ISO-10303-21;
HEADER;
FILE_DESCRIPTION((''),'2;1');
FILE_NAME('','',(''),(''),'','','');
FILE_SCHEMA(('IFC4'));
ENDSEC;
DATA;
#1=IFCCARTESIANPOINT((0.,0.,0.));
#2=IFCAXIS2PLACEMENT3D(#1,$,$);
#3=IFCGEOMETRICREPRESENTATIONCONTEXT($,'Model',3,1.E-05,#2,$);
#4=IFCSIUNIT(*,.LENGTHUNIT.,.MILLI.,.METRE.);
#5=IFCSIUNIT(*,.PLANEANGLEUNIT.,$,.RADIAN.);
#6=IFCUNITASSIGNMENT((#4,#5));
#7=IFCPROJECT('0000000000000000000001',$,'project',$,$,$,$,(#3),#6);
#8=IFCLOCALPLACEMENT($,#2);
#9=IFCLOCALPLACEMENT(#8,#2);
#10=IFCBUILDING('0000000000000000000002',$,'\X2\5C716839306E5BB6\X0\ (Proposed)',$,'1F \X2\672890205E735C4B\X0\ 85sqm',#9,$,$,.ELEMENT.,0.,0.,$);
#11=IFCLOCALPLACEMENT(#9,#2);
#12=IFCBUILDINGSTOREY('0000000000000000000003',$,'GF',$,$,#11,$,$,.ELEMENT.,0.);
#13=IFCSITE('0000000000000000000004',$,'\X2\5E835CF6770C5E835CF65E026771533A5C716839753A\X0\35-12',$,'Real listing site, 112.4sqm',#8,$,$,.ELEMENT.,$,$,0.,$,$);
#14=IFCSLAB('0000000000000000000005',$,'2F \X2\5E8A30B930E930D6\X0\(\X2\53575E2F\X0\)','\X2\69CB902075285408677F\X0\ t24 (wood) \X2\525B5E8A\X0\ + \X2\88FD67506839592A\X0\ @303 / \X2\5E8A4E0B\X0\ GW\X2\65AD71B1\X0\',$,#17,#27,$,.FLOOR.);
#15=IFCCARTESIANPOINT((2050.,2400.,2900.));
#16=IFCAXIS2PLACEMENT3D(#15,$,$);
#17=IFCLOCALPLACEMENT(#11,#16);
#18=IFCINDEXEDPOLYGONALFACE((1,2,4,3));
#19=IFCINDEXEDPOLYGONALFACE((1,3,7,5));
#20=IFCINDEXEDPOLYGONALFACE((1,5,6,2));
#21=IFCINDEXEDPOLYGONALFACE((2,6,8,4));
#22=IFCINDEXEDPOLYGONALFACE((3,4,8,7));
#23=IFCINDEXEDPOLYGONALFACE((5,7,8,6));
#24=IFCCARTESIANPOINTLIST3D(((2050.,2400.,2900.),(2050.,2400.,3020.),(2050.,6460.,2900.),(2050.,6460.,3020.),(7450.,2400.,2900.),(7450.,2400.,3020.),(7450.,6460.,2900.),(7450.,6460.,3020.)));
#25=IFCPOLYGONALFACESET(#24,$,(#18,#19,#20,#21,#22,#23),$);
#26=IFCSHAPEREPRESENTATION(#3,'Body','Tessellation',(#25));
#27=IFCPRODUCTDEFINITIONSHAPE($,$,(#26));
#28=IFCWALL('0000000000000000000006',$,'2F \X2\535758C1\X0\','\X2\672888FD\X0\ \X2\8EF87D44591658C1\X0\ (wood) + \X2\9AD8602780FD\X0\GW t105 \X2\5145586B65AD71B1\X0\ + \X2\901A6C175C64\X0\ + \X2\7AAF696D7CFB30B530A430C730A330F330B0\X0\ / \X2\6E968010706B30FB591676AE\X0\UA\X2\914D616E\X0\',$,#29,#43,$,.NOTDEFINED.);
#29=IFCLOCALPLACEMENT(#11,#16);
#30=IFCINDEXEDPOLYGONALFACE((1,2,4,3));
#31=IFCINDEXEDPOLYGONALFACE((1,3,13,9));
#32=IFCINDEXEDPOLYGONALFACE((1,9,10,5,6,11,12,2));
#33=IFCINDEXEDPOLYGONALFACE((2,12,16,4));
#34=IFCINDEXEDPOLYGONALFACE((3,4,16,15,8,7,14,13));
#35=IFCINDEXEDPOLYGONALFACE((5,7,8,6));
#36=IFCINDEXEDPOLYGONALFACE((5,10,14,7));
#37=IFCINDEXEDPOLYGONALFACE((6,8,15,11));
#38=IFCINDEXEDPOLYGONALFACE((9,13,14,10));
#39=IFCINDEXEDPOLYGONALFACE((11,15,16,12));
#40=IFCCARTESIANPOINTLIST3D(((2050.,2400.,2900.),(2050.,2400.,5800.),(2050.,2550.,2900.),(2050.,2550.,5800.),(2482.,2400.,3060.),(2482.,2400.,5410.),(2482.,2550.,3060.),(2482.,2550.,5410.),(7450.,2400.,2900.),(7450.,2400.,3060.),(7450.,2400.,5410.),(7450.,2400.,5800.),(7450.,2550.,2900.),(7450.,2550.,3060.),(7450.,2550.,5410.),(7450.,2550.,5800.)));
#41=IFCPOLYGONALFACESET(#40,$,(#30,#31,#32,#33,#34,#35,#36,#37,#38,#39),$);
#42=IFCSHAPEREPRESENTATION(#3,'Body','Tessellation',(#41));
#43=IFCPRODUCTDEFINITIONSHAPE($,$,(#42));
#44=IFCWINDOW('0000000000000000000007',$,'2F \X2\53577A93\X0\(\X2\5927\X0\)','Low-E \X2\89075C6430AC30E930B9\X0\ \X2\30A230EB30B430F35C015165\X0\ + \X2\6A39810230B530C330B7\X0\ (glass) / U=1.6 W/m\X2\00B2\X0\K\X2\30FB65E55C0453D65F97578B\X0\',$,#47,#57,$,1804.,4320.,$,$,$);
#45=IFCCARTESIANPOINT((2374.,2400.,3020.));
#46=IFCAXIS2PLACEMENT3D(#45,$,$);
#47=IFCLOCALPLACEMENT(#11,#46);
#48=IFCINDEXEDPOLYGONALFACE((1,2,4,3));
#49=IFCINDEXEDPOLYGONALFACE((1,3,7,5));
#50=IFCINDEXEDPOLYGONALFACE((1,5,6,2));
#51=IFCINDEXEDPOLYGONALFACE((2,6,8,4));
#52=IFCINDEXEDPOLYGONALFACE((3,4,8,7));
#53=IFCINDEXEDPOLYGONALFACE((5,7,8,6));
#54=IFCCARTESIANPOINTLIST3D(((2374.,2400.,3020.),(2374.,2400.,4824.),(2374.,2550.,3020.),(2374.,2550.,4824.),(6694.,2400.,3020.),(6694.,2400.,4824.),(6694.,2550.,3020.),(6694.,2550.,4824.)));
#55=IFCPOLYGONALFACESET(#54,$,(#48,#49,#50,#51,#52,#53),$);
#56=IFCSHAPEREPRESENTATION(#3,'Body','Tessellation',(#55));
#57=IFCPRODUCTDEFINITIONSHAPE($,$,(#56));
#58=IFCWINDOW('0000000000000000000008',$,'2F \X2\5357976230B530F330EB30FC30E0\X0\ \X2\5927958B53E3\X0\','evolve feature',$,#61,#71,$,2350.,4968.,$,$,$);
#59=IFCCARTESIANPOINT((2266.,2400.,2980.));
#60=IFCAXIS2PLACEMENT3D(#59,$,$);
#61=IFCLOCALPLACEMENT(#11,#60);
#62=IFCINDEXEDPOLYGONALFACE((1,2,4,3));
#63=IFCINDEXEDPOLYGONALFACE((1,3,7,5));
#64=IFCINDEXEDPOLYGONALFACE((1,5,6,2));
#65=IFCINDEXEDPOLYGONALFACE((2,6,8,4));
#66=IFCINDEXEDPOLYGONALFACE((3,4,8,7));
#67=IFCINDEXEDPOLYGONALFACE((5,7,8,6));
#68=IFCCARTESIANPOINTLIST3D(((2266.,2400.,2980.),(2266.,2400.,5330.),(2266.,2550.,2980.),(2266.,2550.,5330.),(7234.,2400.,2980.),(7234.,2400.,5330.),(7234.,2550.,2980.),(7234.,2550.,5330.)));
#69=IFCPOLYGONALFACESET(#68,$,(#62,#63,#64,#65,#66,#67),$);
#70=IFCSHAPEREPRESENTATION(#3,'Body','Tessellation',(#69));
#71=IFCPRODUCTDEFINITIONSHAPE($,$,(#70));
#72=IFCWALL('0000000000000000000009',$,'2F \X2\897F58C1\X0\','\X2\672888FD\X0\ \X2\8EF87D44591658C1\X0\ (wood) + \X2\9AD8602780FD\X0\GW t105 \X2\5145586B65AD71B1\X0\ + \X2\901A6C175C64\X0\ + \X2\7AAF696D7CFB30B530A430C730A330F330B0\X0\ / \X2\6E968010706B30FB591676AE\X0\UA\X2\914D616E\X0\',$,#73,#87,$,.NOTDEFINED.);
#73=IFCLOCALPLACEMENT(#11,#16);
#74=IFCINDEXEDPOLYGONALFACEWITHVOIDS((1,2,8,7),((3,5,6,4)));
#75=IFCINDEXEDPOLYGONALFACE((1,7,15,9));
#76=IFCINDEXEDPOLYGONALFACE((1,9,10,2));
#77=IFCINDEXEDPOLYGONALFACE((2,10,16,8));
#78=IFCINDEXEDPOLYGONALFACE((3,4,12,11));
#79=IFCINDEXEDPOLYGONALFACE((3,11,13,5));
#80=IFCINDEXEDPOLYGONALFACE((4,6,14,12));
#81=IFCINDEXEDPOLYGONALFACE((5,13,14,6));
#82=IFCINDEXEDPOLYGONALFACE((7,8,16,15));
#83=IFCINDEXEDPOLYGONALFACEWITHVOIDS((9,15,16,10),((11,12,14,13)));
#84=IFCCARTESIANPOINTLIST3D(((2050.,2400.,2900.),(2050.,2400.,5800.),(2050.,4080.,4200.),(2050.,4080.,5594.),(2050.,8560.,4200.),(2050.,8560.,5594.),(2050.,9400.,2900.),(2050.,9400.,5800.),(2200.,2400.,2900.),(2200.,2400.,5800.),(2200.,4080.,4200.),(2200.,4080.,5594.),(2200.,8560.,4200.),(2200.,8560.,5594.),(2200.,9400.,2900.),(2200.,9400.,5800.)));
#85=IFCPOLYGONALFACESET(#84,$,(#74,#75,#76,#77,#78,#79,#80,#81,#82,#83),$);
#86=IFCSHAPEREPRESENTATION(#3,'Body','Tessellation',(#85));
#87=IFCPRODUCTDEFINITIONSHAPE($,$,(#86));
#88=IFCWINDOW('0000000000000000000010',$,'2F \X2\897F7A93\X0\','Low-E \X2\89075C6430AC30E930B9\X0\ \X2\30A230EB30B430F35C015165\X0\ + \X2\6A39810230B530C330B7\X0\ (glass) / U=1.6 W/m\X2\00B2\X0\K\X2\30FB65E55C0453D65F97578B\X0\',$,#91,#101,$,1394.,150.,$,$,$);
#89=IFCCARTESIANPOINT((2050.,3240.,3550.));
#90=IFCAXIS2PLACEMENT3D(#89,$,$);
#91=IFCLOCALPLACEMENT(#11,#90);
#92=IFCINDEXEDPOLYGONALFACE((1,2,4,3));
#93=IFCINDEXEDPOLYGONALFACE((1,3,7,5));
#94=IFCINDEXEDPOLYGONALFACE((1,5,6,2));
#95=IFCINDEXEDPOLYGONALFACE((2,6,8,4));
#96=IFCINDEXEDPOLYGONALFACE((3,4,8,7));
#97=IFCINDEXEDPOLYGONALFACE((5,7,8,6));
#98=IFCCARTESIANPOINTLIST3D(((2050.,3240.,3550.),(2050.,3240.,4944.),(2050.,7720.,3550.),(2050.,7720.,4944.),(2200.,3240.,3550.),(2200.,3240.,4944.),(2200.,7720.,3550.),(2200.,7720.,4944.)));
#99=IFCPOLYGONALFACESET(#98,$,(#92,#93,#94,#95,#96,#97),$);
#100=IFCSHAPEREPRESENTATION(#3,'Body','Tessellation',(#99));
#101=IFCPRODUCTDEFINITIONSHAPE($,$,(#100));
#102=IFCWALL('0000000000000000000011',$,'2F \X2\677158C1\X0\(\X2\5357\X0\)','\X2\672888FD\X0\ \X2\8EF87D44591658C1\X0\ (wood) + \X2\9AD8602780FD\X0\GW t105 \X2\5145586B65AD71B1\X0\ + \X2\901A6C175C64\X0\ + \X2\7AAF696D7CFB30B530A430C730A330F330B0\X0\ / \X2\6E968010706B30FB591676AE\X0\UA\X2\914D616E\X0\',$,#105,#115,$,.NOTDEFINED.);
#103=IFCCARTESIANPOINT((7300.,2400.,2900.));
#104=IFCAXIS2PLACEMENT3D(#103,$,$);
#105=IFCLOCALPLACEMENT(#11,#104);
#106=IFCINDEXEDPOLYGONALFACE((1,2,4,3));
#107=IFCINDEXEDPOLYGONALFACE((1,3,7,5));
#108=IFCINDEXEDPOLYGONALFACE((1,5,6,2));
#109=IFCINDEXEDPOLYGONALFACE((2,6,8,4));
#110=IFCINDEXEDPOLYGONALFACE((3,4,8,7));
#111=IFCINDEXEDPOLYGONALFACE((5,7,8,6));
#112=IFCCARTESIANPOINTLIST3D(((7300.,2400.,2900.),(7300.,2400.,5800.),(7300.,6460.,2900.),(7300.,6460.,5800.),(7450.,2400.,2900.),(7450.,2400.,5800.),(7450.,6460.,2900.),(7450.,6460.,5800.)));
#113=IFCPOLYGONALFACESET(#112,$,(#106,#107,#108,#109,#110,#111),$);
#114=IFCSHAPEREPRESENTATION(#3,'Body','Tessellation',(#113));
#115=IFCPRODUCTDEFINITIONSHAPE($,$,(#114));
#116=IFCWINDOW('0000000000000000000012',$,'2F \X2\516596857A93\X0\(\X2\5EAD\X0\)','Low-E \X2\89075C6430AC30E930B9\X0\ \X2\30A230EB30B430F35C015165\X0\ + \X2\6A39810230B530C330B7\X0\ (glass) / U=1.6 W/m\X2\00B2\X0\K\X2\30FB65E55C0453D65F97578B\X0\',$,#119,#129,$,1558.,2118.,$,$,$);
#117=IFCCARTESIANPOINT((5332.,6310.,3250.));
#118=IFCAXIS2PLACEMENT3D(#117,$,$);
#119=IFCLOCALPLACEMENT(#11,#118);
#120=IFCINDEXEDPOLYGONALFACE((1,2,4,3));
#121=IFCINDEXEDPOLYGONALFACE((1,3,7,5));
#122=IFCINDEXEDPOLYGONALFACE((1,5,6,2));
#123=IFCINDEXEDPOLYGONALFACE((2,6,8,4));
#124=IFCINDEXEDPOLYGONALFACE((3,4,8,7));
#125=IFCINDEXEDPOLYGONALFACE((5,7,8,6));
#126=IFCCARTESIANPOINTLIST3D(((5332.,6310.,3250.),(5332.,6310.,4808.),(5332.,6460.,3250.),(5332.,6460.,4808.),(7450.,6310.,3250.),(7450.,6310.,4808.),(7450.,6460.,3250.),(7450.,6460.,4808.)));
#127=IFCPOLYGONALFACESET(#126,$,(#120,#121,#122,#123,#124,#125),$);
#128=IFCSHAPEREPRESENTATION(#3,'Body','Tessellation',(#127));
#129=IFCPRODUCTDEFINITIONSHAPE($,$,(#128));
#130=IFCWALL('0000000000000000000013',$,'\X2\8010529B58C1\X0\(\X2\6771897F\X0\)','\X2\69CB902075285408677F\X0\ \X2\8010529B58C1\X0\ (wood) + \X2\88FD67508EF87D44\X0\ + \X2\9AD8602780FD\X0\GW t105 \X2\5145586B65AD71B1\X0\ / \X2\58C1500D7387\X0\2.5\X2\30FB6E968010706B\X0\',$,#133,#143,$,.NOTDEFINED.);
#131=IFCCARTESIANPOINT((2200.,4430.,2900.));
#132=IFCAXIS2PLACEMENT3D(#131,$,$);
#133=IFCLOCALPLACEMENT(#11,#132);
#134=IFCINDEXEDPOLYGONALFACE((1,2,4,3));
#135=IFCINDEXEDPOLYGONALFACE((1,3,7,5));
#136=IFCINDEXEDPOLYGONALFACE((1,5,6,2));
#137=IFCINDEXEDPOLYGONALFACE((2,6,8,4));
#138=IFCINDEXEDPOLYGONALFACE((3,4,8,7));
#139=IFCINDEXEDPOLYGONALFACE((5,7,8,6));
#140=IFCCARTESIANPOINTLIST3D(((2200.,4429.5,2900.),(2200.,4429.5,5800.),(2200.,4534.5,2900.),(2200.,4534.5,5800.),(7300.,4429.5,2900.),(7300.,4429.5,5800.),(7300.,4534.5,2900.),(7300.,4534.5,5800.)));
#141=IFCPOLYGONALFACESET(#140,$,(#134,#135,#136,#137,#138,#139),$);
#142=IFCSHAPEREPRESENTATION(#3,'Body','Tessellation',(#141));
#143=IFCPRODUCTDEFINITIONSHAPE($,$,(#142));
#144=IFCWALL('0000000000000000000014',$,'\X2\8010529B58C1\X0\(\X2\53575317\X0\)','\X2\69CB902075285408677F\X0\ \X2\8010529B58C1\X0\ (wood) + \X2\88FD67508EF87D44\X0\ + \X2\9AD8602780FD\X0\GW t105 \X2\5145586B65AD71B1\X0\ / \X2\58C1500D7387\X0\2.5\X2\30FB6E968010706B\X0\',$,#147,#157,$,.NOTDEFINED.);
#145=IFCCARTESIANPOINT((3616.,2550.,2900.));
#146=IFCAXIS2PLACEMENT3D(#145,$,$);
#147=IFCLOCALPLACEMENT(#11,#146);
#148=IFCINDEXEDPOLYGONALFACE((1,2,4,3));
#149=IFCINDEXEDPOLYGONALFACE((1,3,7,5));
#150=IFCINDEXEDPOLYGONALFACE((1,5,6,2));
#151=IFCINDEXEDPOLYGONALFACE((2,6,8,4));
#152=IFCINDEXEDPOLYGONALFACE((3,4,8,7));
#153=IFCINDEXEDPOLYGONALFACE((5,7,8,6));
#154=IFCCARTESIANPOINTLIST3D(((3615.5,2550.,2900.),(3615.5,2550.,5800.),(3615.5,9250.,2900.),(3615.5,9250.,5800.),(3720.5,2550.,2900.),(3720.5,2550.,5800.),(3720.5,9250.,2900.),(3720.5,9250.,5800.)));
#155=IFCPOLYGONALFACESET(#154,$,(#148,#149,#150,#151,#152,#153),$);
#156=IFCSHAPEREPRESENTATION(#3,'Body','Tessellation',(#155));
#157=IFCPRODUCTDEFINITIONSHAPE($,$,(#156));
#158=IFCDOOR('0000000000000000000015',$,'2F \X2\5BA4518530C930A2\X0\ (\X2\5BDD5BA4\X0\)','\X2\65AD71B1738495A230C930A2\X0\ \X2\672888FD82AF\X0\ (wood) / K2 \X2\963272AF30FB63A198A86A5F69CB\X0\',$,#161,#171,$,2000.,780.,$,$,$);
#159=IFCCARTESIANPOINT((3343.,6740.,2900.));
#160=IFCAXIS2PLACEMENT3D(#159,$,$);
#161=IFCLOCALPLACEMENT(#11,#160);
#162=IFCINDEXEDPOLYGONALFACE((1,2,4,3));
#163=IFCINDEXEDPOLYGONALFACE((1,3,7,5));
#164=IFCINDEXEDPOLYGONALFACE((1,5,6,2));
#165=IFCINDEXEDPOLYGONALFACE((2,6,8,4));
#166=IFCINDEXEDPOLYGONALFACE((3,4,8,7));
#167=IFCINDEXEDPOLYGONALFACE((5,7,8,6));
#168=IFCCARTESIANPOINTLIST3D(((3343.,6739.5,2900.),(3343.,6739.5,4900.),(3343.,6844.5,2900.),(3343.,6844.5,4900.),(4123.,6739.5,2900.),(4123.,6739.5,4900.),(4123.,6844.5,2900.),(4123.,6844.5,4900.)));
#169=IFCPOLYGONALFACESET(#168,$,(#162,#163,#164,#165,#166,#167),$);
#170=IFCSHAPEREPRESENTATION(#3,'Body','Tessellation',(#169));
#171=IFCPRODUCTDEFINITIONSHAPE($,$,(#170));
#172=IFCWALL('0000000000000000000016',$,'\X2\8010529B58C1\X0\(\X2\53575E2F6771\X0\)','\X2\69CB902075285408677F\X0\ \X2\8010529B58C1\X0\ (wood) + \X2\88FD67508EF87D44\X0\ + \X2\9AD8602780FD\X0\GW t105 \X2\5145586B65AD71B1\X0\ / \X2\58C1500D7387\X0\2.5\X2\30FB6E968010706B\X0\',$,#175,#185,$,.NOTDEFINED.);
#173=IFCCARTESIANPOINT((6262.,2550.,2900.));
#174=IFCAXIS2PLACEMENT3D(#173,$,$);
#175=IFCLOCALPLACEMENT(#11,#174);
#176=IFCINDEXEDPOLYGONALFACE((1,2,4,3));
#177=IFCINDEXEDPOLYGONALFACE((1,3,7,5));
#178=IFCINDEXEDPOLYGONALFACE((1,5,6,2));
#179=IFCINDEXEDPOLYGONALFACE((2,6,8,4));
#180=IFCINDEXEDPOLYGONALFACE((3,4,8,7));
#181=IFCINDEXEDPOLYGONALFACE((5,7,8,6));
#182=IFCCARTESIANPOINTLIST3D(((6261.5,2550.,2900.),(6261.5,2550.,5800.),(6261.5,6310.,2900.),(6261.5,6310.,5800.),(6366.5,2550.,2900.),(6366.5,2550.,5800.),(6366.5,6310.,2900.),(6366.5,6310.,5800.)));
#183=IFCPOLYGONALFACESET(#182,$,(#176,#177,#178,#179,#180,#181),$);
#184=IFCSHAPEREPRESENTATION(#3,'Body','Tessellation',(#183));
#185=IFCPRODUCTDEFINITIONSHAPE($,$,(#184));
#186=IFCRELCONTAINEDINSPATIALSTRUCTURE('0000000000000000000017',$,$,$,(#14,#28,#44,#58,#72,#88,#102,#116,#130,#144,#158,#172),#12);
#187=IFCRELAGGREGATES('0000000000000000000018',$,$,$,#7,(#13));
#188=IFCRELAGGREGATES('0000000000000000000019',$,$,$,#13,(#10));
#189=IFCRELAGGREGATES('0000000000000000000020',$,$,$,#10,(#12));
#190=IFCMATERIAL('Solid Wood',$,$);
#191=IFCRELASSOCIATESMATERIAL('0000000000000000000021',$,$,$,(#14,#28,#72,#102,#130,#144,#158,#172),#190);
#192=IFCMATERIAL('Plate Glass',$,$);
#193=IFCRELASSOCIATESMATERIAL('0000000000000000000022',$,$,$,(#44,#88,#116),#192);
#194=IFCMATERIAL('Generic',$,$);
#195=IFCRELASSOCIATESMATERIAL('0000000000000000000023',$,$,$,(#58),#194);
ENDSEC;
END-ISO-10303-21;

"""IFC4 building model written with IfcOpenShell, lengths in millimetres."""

from ifc_helpers import new_model, si_unit, frame, frame_2d, origin, place, context, project, spatial, rectangle, extrude, material, element, fill, save


model = new_model("IFC4")

# Units and contexts
model_context = context("Model", 3, precision=1e-05, world=origin())
ifc_project = project(units=[si_unit("LENGTHUNIT", "METRE", prefix="MILLI"), si_unit("PLANEANGLEUNIT", "RADIAN")], contexts=[model_context])

# Site, building, storey
site_placement = place(None, origin())
site = spatial("IfcSite", under=ifc_project, at=site_placement, Name="広島県広島市東区山根町35-12", ObjectType="Real listing site, 112.4sqm", CompositionType="ELEMENT", RefElevation=0.0)
building_placement = place(site_placement, origin())
building = spatial("IfcBuilding", under=site, at=building_placement, Name="山根の家 (Proposed)", ObjectType="1F 木造平屋 85sqm", CompositionType="ELEMENT", ElevationOfRefHeight=0.0, ElevationOfTerrain=0.0)
storey_placement = place(building_placement, origin())
storey = spatial("IfcBuildingStorey", under=building, at=storey_placement, Name="GF", CompositionType="ELEMENT", Elevation=0.0)

# Slab
ifc_material_1 = material(Name="Solid Wood")
slab_placement = place(storey_placement, frame((2050.0, 2400.0, 2900.0)))
element("IfcSlab", 1, at=slab_placement, inside=storey, material=ifc_material_1, Name="2F 床スラブ(南帯)", Description="構造用合板 t24 (wood) 剛床 + 製材根太 @303 / 床下 GW断熱", PredefinedType="FLOOR", context=model_context, shape_type="SweptSolid", body=[
    extrude(rectangle(XDim=5400.0, YDim=4060.0, at=frame_2d((2700.0, 2030.0))), frame((2050.0, 2400.0, 2900.0)), (0.0, 0.0, 1.0), 120.0),
])

# Wall, openings, windows
wall_1_placement = place(storey_placement, frame((2050.0, 2400.0, 2900.0)))
wall_1 = element("IfcWall", 2, at=wall_1_placement, inside=storey, material=ifc_material_1, Name="2F 南壁", Description="木製 軸組外壁 (wood) + 高性能GW t105 充填断熱 + 通気層 + 窯業系サイディング / 準耐火・外皮UA配慮", PredefinedType="NOTDEFINED", context=model_context, shape_type="SweptSolid", body=[
    extrude(rectangle(XDim=5400.0, YDim=150.0, at=frame_2d((2700.0, 75.0))), frame((2050.0, 2400.0, 2900.0)), (0.0, 0.0, 1.0), 2900.0),
])
opening_1_placement = place(storey_placement, frame((2374.0, 2400.0, 3020.0)))
opening_1 = element("IfcOpeningElement", 3, at=opening_1_placement, cuts=wall_1, PredefinedType="NOTDEFINED", context=model_context, shape_type="SweptSolid", body=[
    extrude(rectangle(XDim=4320.0, YDim=150.0, at=frame_2d((2160.0, 75.0))), frame((2374.0, 2400.0, 3020.0)), (0.0, 0.0, 1.0), 1804.0),
])
opening_2_placement = place(storey_placement, frame((2266.0, 2400.0, 2980.0)))
opening_2 = element("IfcOpeningElement", 4, at=opening_2_placement, cuts=wall_1, PredefinedType="NOTDEFINED", context=model_context, shape_type="SweptSolid", body=[
    extrude(rectangle(XDim=4968.0, YDim=150.0, at=frame_2d((2484.0, 75.0))), frame((2266.0, 2400.0, 2980.0)), (0.0, 0.0, 1.0), 2350.0),
])
ifc_material_2 = material(Name="Plate Glass")
window_1_placement = place(storey_placement, frame((2374.0, 2400.0, 3020.0)))
window_1 = element("IfcWindow", 5, at=window_1_placement, inside=storey, material=ifc_material_2, Name="2F 南窓(大)", Description="Low-E 複層ガラス アルゴン封入 + 樹脂サッシ (glass) / U=1.6 W/m²K・日射取得型", OverallHeight=1804.0, OverallWidth=4320.0, context=model_context, shape_type="SweptSolid", body=[
    extrude(rectangle(XDim=4320.0, YDim=150.0, at=frame_2d((2160.0, 75.0))), frame((2374.0, 2400.0, 3020.0)), (0.0, 0.0, 1.0), 1804.0),
])
fill(opening_1, window_1)
ifc_material_3 = material(Name="Generic")
window_2_placement = place(storey_placement, frame((2266.0, 2400.0, 2980.0)))
window_2 = element("IfcWindow", 6, at=window_2_placement, inside=storey, material=ifc_material_3, Name="2F 南面サンルーム 大開口", Description="evolve feature", OverallHeight=2350.0, OverallWidth=4968.0, context=model_context, shape_type="SweptSolid", body=[
    extrude(rectangle(XDim=4968.0, YDim=150.0, at=frame_2d((2484.0, 75.0))), frame((2266.0, 2400.0, 2980.0)), (0.0, 0.0, 1.0), 2350.0),
])
fill(opening_2, window_2)

# Walls, openings, windows
wall_2_placement = place(storey_placement, frame((2050.0, 2400.0, 2900.0)))
wall_2 = element("IfcWall", 7, at=wall_2_placement, inside=storey, material=ifc_material_1, Name="2F 西壁", Description="木製 軸組外壁 (wood) + 高性能GW t105 充填断熱 + 通気層 + 窯業系サイディング / 準耐火・外皮UA配慮", PredefinedType="NOTDEFINED", context=model_context, shape_type="SweptSolid", body=[
    extrude(rectangle(XDim=150.0, YDim=7000.0, at=frame_2d((75.0, 3500.0))), frame((2050.0, 2400.0, 2900.0)), (0.0, 0.0, 1.0), 2900.0),
])
opening_3_placement = place(storey_placement, frame((2050.0, 3240.0, 3550.0)))
opening_3 = element("IfcOpeningElement", 8, at=opening_3_placement, cuts=wall_2, PredefinedType="NOTDEFINED", context=model_context, shape_type="SweptSolid", body=[
    extrude(rectangle(XDim=150.0, YDim=4480.0, at=frame_2d((75.0, 2240.0))), frame((2050.0, 3240.0, 3550.0)), (0.0, 0.0, 1.0), 1394.0),
])
window_3_placement = place(storey_placement, frame((2050.0, 3240.0, 3550.0)))
window_3 = element("IfcWindow", 9, at=window_3_placement, inside=storey, material=ifc_material_2, Name="2F 西窓", Description="Low-E 複層ガラス アルゴン封入 + 樹脂サッシ (glass) / U=1.6 W/m²K・日射取得型", OverallHeight=1394.0, OverallWidth=150.0, context=model_context, shape_type="SweptSolid", body=[
    extrude(rectangle(XDim=150.0, YDim=4480.0, at=frame_2d((75.0, 2240.0))), frame((2050.0, 3240.0, 3550.0)), (0.0, 0.0, 1.0), 1394.0),
])
fill(opening_3, window_3)
wall_3_placement = place(storey_placement, frame((7300.0, 2400.0, 2900.0)))
wall_3 = element("IfcWall", 10, at=wall_3_placement, inside=storey, material=ifc_material_1, Name="2F 東壁(南)", Description="木製 軸組外壁 (wood) + 高性能GW t105 充填断熱 + 通気層 + 窯業系サイディング / 準耐火・外皮UA配慮", PredefinedType="NOTDEFINED", context=model_context, shape_type="SweptSolid", body=[
    extrude(rectangle(XDim=150.0, YDim=4060.0, at=frame_2d((75.0, 2030.0))), frame((7300.0, 2400.0, 2900.0)), (0.0, 0.0, 1.0), 2900.0),
])
opening_4_placement = place(storey_placement, frame((5332.0, 6310.0, 3250.0)))
opening_4 = element("IfcOpeningElement", 11, at=opening_4_placement, cuts=wall_3, PredefinedType="NOTDEFINED", context=model_context, shape_type="SweptSolid", body=[
    extrude(rectangle(XDim=2118.0, YDim=150.0, at=frame_2d((1059.0, 75.0))), frame((5332.0, 6310.0, 3250.0)), (0.0, 0.0, 1.0), 1558.0),
])
window_4_placement = place(storey_placement, frame((5332.0, 6310.0, 3250.0)))
window_4 = element("IfcWindow", 12, at=window_4_placement, inside=storey, material=ifc_material_2, Name="2F 入隅窓(庭)", Description="Low-E 複層ガラス アルゴン封入 + 樹脂サッシ (glass) / U=1.6 W/m²K・日射取得型", OverallHeight=1558.0, OverallWidth=2118.0, context=model_context, shape_type="SweptSolid", body=[
    extrude(rectangle(XDim=2118.0, YDim=150.0, at=frame_2d((1059.0, 75.0))), frame((5332.0, 6310.0, 3250.0)), (0.0, 0.0, 1.0), 1558.0),
])
fill(opening_4, window_4)

# Wall
wall_4_placement = place(storey_placement, frame((2200.0, 4430.0, 2900.0)))
element("IfcWall", 13, at=wall_4_placement, inside=storey, material=ifc_material_1, Name="耐力壁(東西)", Description="構造用合板 耐力壁 (wood) + 製材軸組 + 高性能GW t105 充填断熱 / 壁倍率2.5・準耐火", PredefinedType="NOTDEFINED", context=model_context, shape_type="SweptSolid", body=[
    extrude(rectangle(XDim=5100.0, YDim=105.0, at=frame_2d((2550.0, 52.0))), frame((2200.0, 4430.0, 2900.0)), (0.0, 0.0, 1.0), 2900.0),
])

# Wall, opening, door
wall_5_placement = place(storey_placement, frame((3616.0, 2550.0, 2900.0)))
wall_5 = element("IfcWall", 14, at=wall_5_placement, inside=storey, material=ifc_material_1, Name="耐力壁(南北)", Description="構造用合板 耐力壁 (wood) + 製材軸組 + 高性能GW t105 充填断熱 / 壁倍率2.5・準耐火", PredefinedType="NOTDEFINED", context=model_context, shape_type="SweptSolid", body=[
    extrude(rectangle(XDim=105.0, YDim=6700.0, at=frame_2d((52.0, 3350.0))), frame((3616.0, 2550.0, 2900.0)), (0.0, 0.0, 1.0), 2900.0),
])
opening_5_placement = place(storey_placement, frame((3343.0, 6740.0, 2900.0)))
opening_5 = element("IfcOpeningElement", 15, at=opening_5_placement, cuts=wall_5, PredefinedType="NOTDEFINED", context=model_context, shape_type="SweptSolid", body=[
    extrude(rectangle(XDim=780.0, YDim=105.0, at=frame_2d((390.0, 52.0))), frame((3343.0, 6740.0, 2900.0)), (0.0, 0.0, 1.0), 2000.0),
])
door_placement = place(storey_placement, frame((3343.0, 6740.0, 2900.0)))
door = element("IfcDoor", 16, at=door_placement, inside=storey, material=ifc_material_1, Name="2F 室内ドア (寝室)", Description="断熱玄関ドア 木製芯 (wood) / K2 防犯・採風機構", OverallHeight=2000.0, OverallWidth=780.0, context=model_context, shape_type="SweptSolid", body=[
    extrude(rectangle(XDim=780.0, YDim=105.0, at=frame_2d((390.0, 52.0))), frame((3343.0, 6740.0, 2900.0)), (0.0, 0.0, 1.0), 2000.0),
])
fill(opening_5, door)

# Wall
wall_6_placement = place(storey_placement, frame((6262.0, 2550.0, 2900.0)))
element("IfcWall", 17, at=wall_6_placement, inside=storey, material=ifc_material_1, Name="耐力壁(南帯東)", Description="構造用合板 耐力壁 (wood) + 製材軸組 + 高性能GW t105 充填断熱 / 壁倍率2.5・準耐火", PredefinedType="NOTDEFINED", context=model_context, shape_type="SweptSolid", body=[
    extrude(rectangle(XDim=105.0, YDim=3760.0, at=frame_2d((52.0, 1880.0))), frame((6262.0, 2550.0, 2900.0)), (0.0, 0.0, 1.0), 2900.0),
])

save(model, "model.ifc")
